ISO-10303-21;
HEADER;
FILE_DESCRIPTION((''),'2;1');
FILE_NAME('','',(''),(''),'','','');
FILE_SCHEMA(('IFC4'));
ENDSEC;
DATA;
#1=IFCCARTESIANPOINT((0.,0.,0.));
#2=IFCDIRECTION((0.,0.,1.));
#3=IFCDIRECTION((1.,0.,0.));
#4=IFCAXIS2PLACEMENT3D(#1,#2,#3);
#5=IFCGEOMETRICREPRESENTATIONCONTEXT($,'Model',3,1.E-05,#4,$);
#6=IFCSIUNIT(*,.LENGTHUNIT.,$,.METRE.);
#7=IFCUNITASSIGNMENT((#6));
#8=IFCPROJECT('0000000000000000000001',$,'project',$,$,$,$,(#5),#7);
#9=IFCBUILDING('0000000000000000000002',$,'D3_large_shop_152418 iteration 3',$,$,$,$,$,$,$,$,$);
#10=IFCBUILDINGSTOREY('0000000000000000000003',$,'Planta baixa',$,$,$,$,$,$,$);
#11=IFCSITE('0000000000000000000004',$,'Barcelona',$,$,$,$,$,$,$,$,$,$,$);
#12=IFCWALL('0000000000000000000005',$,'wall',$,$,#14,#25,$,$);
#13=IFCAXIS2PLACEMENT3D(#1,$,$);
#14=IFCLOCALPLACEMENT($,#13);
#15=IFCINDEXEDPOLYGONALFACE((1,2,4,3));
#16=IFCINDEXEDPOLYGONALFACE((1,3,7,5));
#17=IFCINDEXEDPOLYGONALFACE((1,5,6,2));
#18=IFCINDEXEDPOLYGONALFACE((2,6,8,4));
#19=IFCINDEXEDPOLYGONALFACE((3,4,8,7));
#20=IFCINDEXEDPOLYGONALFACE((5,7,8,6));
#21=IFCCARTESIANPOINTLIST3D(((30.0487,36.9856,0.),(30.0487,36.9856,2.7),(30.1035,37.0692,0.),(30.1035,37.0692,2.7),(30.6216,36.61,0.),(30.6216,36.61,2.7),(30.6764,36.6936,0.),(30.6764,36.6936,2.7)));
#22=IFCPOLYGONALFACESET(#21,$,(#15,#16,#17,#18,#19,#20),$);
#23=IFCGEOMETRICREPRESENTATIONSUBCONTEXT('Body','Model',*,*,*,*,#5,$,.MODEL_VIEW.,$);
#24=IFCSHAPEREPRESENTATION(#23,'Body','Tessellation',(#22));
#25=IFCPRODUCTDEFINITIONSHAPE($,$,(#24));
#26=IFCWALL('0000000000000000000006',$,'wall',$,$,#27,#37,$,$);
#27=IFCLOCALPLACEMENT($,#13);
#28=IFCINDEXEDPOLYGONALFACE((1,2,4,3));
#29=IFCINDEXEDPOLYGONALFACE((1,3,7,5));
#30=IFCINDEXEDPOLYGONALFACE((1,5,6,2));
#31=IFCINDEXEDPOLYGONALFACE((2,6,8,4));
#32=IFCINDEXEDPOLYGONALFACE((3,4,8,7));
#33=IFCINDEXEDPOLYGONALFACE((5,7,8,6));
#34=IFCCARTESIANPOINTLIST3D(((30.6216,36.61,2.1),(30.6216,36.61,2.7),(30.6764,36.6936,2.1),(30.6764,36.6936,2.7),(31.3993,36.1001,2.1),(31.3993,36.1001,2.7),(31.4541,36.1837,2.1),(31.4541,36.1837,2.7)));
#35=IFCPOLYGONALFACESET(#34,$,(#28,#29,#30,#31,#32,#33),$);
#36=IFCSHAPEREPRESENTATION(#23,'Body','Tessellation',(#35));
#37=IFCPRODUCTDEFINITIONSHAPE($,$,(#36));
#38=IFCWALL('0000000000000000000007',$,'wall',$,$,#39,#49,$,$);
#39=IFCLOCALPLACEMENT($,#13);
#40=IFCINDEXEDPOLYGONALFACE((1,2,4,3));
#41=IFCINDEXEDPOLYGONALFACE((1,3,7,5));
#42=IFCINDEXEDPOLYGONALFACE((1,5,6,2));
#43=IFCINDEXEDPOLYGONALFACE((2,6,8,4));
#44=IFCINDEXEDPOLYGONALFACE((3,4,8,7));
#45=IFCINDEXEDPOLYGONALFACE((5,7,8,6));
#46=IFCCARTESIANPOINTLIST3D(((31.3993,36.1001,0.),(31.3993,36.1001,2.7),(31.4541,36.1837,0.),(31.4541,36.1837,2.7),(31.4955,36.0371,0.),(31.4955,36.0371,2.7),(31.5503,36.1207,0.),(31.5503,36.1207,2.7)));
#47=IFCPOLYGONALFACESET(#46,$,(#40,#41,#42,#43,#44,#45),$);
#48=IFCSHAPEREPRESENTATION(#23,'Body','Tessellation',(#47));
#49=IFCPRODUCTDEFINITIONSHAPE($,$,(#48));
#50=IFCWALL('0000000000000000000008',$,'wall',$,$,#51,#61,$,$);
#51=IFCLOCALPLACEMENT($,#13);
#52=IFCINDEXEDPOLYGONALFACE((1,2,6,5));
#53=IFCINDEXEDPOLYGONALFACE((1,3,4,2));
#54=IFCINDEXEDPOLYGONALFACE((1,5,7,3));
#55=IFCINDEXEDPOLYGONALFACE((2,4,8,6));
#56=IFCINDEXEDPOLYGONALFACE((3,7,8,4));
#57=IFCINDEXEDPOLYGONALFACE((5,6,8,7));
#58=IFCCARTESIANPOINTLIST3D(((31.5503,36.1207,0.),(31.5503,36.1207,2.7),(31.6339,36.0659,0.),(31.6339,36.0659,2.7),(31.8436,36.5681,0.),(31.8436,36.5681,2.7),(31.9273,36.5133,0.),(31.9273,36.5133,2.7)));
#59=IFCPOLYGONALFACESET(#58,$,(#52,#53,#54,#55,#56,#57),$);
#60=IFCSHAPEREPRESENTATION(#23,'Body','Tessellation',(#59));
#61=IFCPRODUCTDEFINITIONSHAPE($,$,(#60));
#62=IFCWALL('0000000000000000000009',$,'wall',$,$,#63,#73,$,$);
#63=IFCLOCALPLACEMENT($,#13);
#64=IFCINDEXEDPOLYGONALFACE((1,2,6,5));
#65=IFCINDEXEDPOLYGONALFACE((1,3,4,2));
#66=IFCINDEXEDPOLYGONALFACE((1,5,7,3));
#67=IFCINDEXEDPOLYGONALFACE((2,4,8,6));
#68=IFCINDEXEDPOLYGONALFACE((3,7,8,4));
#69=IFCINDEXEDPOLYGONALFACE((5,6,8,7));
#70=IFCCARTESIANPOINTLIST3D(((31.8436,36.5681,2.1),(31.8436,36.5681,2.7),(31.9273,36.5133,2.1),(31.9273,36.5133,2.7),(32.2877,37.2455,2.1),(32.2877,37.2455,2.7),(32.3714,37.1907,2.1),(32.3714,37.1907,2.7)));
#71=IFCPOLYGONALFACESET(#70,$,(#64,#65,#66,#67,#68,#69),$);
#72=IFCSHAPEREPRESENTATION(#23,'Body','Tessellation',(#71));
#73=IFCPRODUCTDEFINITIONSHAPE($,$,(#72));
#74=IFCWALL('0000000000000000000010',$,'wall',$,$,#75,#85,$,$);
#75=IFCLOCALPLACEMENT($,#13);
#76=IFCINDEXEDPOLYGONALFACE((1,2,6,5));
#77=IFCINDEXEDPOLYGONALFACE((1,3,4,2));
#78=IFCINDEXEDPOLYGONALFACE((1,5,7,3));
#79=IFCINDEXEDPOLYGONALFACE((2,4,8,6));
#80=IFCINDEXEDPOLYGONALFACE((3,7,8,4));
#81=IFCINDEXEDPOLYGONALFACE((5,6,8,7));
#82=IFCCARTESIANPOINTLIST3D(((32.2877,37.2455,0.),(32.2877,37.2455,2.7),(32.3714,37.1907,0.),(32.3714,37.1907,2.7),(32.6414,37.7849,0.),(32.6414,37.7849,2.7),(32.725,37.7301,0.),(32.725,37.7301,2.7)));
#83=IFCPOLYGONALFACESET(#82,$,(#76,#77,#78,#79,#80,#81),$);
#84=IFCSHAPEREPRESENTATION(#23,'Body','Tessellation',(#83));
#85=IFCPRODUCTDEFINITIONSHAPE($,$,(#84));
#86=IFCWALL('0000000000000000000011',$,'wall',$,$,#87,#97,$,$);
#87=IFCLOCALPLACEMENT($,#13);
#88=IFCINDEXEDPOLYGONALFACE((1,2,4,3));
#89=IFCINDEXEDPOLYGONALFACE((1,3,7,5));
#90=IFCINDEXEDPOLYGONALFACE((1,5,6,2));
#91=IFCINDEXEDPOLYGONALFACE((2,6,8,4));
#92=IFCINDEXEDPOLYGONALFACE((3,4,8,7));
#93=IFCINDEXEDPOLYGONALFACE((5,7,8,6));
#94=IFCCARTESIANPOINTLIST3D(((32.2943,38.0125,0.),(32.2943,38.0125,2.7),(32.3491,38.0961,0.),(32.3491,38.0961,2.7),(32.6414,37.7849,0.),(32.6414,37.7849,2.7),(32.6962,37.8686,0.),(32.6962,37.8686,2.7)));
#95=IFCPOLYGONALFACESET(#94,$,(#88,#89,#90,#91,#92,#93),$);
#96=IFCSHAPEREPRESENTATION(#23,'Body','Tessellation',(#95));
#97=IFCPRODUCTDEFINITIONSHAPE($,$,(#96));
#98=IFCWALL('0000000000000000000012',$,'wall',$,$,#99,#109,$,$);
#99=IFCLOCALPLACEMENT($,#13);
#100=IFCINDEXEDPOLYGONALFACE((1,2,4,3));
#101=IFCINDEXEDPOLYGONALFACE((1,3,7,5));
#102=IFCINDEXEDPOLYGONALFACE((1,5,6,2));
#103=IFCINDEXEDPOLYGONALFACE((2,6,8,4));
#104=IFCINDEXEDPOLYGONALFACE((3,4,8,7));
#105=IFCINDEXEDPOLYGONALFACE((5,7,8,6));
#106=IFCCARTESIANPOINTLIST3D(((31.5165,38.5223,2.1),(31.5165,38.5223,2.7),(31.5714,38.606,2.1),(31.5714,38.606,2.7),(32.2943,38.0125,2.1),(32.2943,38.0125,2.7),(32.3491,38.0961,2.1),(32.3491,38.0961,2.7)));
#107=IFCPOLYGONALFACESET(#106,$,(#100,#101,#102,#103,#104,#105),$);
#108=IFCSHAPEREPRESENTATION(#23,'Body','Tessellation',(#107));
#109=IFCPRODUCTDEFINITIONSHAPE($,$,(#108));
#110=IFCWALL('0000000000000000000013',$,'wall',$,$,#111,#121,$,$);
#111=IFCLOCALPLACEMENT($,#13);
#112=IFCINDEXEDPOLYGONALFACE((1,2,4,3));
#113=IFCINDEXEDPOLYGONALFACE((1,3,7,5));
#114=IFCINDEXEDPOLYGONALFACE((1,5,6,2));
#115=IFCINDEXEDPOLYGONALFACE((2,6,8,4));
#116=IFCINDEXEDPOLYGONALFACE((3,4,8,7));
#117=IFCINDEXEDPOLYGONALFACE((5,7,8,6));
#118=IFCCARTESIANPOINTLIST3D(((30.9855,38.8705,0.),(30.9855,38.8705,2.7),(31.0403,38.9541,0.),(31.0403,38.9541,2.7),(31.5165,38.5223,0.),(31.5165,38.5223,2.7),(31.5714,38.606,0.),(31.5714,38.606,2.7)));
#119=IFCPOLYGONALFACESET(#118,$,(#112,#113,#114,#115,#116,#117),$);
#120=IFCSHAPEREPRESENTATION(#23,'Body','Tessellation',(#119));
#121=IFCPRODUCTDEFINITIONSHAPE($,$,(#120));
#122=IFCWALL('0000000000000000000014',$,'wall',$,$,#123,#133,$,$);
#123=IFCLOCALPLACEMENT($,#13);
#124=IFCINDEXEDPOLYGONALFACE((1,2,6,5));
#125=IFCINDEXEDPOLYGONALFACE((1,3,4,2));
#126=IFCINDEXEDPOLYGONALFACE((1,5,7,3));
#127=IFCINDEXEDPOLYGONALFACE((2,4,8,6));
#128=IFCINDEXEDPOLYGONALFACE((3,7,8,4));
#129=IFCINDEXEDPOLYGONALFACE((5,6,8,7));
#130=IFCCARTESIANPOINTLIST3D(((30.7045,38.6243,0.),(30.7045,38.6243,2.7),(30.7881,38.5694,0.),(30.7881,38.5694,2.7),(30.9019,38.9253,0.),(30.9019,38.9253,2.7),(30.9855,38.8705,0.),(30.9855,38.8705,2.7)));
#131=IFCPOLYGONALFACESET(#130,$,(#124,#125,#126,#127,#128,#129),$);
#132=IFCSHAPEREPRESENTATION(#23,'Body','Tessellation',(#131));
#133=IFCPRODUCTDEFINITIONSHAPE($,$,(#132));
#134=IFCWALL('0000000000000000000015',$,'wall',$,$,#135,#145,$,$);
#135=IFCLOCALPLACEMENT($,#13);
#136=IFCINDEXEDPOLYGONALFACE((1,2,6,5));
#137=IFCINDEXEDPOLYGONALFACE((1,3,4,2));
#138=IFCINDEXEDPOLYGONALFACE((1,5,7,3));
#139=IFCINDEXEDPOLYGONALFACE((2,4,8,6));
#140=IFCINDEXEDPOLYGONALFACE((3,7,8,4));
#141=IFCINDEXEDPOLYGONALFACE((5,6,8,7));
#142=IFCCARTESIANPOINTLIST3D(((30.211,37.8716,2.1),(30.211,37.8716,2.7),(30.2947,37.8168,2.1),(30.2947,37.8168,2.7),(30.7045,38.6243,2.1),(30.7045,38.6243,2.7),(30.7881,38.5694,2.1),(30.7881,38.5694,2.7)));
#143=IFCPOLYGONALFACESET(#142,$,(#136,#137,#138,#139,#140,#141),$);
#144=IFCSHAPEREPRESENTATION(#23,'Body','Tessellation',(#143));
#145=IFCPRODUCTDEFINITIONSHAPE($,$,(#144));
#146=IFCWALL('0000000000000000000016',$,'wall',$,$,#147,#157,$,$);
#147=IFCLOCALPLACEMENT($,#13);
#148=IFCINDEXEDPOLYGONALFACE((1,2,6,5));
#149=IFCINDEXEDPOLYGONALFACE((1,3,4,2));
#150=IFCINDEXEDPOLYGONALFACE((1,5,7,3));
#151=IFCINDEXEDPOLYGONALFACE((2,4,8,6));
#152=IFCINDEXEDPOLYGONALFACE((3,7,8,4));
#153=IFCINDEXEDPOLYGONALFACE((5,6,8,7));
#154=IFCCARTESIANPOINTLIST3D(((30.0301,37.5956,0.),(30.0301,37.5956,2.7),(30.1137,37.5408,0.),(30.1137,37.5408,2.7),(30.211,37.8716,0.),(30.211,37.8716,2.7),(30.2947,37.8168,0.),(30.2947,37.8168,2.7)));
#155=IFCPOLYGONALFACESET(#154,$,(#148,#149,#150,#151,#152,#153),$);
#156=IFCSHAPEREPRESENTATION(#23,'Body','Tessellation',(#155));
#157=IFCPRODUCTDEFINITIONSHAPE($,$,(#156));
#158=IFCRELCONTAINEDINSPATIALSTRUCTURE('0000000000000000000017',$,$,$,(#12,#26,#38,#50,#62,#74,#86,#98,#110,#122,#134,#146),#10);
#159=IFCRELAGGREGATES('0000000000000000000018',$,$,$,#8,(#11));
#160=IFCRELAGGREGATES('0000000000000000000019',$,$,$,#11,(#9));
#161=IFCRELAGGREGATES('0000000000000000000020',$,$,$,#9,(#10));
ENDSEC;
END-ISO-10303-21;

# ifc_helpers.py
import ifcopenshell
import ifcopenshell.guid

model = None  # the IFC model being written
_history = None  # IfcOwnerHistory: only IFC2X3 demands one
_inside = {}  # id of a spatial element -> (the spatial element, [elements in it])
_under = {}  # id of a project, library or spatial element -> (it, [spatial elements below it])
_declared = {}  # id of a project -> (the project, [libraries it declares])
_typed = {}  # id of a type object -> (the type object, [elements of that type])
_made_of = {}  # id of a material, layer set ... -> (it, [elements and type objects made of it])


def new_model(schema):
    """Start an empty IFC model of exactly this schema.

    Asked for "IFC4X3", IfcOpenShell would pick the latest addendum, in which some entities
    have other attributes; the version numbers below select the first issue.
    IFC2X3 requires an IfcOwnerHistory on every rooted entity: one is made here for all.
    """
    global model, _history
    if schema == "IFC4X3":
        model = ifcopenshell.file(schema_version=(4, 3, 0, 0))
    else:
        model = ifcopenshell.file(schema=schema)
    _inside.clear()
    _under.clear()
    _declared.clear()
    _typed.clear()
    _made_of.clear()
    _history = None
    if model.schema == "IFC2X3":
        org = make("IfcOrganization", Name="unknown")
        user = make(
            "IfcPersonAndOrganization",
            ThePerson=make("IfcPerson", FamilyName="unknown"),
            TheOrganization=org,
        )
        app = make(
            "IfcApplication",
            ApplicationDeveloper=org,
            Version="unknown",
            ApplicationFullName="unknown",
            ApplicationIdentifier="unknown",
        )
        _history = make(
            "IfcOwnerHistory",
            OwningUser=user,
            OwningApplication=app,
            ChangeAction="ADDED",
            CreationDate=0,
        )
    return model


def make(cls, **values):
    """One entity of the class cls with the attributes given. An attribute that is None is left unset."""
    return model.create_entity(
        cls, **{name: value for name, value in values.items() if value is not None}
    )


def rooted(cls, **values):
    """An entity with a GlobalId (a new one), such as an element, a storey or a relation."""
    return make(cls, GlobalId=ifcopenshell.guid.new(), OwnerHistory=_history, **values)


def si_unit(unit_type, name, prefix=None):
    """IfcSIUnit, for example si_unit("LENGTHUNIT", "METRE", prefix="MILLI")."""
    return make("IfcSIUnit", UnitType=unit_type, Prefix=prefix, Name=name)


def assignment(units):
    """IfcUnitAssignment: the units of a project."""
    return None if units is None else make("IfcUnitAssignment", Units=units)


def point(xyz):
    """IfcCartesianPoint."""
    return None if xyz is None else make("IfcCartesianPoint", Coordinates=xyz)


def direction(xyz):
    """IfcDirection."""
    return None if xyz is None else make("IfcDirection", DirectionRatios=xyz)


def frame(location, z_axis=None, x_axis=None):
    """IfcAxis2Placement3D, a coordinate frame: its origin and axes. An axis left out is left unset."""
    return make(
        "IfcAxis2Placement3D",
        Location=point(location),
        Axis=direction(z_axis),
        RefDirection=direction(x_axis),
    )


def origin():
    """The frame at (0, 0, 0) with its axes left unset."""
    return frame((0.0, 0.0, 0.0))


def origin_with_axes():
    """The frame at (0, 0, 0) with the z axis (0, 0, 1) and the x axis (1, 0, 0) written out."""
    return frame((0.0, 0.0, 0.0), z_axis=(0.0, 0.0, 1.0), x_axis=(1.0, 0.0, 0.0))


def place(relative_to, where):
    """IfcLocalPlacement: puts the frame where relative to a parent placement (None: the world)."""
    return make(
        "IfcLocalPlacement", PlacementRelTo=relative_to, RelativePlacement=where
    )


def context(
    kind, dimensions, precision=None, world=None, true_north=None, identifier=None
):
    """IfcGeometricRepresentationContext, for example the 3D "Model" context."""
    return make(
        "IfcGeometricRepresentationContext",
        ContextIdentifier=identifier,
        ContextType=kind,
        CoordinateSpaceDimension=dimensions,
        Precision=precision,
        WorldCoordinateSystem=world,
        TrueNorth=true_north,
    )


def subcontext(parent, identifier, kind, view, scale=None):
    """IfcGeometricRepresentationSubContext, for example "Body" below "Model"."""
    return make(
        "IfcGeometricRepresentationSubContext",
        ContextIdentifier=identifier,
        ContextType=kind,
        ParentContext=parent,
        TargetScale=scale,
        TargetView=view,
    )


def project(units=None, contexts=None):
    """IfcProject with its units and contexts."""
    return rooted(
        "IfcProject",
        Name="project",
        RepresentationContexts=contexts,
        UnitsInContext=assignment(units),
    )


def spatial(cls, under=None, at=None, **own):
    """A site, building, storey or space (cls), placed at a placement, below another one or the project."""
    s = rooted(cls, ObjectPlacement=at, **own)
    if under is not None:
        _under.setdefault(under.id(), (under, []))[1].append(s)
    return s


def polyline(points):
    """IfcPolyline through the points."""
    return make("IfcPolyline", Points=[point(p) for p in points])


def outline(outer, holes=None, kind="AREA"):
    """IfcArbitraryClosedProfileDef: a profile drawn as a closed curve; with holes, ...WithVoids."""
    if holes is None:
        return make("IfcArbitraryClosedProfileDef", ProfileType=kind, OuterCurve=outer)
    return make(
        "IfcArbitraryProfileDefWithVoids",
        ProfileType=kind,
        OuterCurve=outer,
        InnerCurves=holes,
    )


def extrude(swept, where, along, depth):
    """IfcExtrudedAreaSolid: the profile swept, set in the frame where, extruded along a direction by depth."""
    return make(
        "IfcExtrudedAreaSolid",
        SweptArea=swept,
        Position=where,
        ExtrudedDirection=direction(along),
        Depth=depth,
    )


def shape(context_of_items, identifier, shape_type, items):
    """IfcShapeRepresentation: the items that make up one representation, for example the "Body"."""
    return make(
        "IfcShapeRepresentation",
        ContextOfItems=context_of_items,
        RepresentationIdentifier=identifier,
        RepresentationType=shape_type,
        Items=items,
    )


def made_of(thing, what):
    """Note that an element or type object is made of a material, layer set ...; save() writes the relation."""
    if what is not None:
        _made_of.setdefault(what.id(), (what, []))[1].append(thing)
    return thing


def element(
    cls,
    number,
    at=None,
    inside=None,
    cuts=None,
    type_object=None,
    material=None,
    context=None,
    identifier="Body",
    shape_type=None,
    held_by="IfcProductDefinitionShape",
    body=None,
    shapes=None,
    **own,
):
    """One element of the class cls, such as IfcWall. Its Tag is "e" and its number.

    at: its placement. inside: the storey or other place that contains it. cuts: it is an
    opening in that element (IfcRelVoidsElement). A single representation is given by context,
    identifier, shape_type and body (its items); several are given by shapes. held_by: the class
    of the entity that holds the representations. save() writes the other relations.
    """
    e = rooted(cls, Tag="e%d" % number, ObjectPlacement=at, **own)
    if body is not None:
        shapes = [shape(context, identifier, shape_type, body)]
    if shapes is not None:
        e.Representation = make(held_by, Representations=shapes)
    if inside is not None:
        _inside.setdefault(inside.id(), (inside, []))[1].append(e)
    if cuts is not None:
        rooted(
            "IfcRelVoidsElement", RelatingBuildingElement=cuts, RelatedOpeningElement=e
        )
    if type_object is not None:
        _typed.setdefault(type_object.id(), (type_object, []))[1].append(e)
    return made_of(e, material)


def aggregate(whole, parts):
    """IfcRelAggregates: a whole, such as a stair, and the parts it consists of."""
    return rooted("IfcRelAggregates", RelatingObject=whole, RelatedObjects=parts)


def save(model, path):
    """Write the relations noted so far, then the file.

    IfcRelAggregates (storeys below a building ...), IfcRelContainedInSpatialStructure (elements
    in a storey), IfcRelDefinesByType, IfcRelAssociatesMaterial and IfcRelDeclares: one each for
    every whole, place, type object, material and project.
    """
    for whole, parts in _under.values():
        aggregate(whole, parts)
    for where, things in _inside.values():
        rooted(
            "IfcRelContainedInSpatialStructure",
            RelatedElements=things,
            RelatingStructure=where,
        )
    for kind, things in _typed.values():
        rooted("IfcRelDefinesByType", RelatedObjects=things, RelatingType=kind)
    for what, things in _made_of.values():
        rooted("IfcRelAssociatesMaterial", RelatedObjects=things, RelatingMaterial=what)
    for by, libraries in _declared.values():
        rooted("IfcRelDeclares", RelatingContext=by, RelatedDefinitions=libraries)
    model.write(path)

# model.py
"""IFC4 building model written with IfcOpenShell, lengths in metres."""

from ifc_helpers import new_model, si_unit, frame, origin, origin_with_axes, place, context, subcontext, project, spatial, polyline, outline, extrude, element, save


model = new_model("IFC4")

# Units and contexts
model_context = context("Model", 3, precision=1e-05, world=origin_with_axes())
body_context = subcontext(model_context, "Body", "Model", "MODEL_VIEW")
ifc_project = project(units=[si_unit("LENGTHUNIT", "METRE")], contexts=[model_context])

# Site, building, storey
site = spatial("IfcSite", under=ifc_project, Name="Barcelona")
building = spatial("IfcBuilding", under=site, Name="D3_large_shop_152418 iteration 3")
storey = spatial("IfcBuildingStorey", under=building, Name="Planta baixa")

# Walls
wall_1_placement = place(None, origin_with_axes())
element("IfcWall", 1, at=wall_1_placement, inside=storey, Name="wall", context=body_context, shape_type="SweptSolid", body=[
    extrude(outline(polyline([(30.1035, 37.0692), (30.6764, 36.6936), (30.6216, 36.61), (30.0487, 36.9856), (30.1035, 37.0692)])), origin(), (0.0, 0.0, 1.0), 2.7),
])
wall_2_placement = place(None, origin_with_axes())
element("IfcWall", 2, at=wall_2_placement, inside=storey, Name="wall", context=body_context, shape_type="SweptSolid", body=[
    extrude(outline(polyline([(30.6764, 36.6936), (31.4541, 36.1837), (31.3993, 36.1001), (30.6216, 36.61), (30.6764, 36.6936)])), frame((0.0, 0.0, 2.1)), (0.0, 0.0, 1.0), 0.6),
])
wall_3_placement = place(None, origin_with_axes())
element("IfcWall", 3, at=wall_3_placement, inside=storey, Name="wall", context=body_context, shape_type="SweptSolid", body=[
    extrude(outline(polyline([(31.4541, 36.1837), (31.5503, 36.1207), (31.4955, 36.0371), (31.3993, 36.1001), (31.4541, 36.1837)])), origin(), (0.0, 0.0, 1.0), 2.7),
])
wall_4_placement = place(None, origin_with_axes())
element("IfcWall", 4, at=wall_4_placement, inside=storey, Name="wall", context=body_context, shape_type="SweptSolid", body=[
    extrude(outline(polyline([(31.5503, 36.1207), (31.8436, 36.5681), (31.9273, 36.5133), (31.6339, 36.0659), (31.5503, 36.1207)])), origin(), (0.0, 0.0, 1.0), 2.7),
])
wall_5_placement = place(None, origin_with_axes())
element("IfcWall", 5, at=wall_5_placement, inside=storey, Name="wall", context=body_context, shape_type="SweptSolid", body=[
    extrude(outline(polyline([(31.8436, 36.5681), (32.2877, 37.2455), (32.3714, 37.1907), (31.9273, 36.5133), (31.8436, 36.5681)])), frame((0.0, 0.0, 2.1)), (0.0, 0.0, 1.0), 0.6),
])
wall_6_placement = place(None, origin_with_axes())
element("IfcWall", 6, at=wall_6_placement, inside=storey, Name="wall", context=body_context, shape_type="SweptSolid", body=[
    extrude(outline(polyline([(32.2877, 37.2455), (32.6414, 37.7849), (32.725, 37.7301), (32.3714, 37.1907), (32.2877, 37.2455)])), origin(), (0.0, 0.0, 1.0), 2.7),
])
wall_7_placement = place(None, origin_with_axes())
element("IfcWall", 7, at=wall_7_placement, inside=storey, Name="wall", context=body_context, shape_type="SweptSolid", body=[
    extrude(outline(polyline([(32.6414, 37.7849), (32.2943, 38.0125), (32.3491, 38.0961), (32.6962, 37.8686), (32.6414, 37.7849)])), origin(), (0.0, 0.0, 1.0), 2.7),
])
wall_8_placement = place(None, origin_with_axes())
element("IfcWall", 8, at=wall_8_placement, inside=storey, Name="wall", context=body_context, shape_type="SweptSolid", body=[
    extrude(outline(polyline([(32.2943, 38.0125), (31.5165, 38.5223), (31.5714, 38.606), (32.3491, 38.0961), (32.2943, 38.0125)])), frame((0.0, 0.0, 2.1)), (0.0, 0.0, 1.0), 0.6),
])
wall_9_placement = place(None, origin_with_axes())
element("IfcWall", 9, at=wall_9_placement, inside=storey, Name="wall", context=body_context, shape_type="SweptSolid", body=[
    extrude(outline(polyline([(31.5165, 38.5223), (30.9855, 38.8705), (31.0403, 38.9541), (31.5714, 38.606), (31.5165, 38.5223)])), origin(), (0.0, 0.0, 1.0), 2.7),
])
wall_10_placement = place(None, origin_with_axes())
element("IfcWall", 10, at=wall_10_placement, inside=storey, Name="wall", context=body_context, shape_type="SweptSolid", body=[
    extrude(outline(polyline([(30.9855, 38.8705), (30.7881, 38.5694), (30.7045, 38.6243), (30.9019, 38.9253), (30.9855, 38.8705)])), origin(), (0.0, 0.0, 1.0), 2.7),
])
wall_11_placement = place(None, origin_with_axes())
element("IfcWall", 11, at=wall_11_placement, inside=storey, Name="wall", context=body_context, shape_type="SweptSolid", body=[
    extrude(outline(polyline([(30.7881, 38.5694), (30.2947, 37.8168), (30.211, 37.8716), (30.7045, 38.6243), (30.7881, 38.5694)])), frame((0.0, 0.0, 2.1)), (0.0, 0.0, 1.0), 0.6),
])
wall_12_placement = place(None, origin_with_axes())
element("IfcWall", 12, at=wall_12_placement, inside=storey, Name="wall", context=body_context, shape_type="SweptSolid", body=[
    extrude(outline(polyline([(30.2947, 37.8168), (30.1137, 37.5408), (30.0301, 37.5956), (30.211, 37.8716), (30.2947, 37.8168)])), origin(), (0.0, 0.0, 1.0), 2.7),
])

save(model, "model.ifc")
